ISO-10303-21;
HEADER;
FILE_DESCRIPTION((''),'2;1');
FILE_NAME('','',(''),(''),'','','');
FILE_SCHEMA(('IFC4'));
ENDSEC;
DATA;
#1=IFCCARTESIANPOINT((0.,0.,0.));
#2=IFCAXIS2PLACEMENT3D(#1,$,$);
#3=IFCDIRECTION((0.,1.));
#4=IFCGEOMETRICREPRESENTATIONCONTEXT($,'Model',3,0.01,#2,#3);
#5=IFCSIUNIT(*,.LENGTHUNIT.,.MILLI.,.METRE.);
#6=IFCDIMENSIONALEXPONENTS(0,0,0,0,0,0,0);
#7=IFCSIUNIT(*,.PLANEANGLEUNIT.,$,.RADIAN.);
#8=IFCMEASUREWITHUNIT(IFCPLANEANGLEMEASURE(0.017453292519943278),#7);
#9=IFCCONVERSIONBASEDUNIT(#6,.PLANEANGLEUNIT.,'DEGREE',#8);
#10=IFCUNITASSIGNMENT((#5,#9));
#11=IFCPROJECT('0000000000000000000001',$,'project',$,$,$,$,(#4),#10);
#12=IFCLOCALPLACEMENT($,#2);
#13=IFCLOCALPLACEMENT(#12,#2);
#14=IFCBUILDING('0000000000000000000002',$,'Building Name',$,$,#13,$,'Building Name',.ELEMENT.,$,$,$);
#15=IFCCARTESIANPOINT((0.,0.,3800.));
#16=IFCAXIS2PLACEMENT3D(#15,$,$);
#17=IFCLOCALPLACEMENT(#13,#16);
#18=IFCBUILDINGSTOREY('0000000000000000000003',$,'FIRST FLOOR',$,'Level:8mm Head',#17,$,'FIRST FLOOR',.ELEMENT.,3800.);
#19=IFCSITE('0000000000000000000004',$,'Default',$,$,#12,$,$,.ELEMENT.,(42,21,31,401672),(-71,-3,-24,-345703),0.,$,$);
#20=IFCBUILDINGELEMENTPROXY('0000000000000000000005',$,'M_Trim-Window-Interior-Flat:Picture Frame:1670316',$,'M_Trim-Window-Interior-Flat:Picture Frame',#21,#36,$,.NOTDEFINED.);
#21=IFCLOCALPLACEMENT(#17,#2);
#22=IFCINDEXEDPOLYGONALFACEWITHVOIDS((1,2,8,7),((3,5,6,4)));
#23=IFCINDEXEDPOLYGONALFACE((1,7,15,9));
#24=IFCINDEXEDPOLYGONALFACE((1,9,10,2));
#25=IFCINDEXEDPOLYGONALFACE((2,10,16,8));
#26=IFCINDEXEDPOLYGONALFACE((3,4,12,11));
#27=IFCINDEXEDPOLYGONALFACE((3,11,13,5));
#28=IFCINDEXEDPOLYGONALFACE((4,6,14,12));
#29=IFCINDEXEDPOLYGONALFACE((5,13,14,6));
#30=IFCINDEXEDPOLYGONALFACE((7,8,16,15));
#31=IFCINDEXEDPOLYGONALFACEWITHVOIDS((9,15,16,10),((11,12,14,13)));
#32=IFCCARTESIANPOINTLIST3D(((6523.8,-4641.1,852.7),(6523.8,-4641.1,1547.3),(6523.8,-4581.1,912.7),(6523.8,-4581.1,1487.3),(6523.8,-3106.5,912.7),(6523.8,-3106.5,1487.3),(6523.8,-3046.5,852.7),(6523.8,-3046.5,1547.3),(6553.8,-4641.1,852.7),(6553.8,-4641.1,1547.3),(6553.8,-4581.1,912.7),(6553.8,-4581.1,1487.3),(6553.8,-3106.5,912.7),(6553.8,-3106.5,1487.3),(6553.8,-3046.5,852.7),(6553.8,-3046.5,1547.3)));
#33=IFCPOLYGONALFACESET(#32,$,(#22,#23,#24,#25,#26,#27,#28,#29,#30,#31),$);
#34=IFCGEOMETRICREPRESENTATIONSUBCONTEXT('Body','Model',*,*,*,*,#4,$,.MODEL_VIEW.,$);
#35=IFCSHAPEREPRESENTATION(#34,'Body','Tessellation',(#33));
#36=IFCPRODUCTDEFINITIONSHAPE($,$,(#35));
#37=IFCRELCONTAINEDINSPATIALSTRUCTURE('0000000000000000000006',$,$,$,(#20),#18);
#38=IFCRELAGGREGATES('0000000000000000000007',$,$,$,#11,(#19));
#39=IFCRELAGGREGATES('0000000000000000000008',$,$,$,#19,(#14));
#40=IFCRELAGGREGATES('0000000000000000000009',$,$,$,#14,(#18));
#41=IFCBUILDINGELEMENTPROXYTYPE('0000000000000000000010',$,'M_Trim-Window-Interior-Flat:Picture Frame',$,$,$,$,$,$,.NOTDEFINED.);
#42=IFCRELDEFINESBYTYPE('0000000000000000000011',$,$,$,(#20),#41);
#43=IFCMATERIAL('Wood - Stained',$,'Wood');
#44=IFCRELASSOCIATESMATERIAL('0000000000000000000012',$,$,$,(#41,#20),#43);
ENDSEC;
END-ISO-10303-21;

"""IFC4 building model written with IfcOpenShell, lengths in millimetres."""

from ifc_helpers import new_model, entity, si_unit, converted_unit, direction, frame, origin, place, context, subcontext, project, spatial, indexed_curve, outline, extrude, source, transform, mapped, material, type_object, type_shapes, element, save


model = new_model("IFC4")

# Units and contexts
model_context = context("Model", 3, precision=0.01, world=origin(), true_north=direction((0.0, 1.0)))
body_context = subcontext(model_context, "Body", "Model", "MODEL_VIEW")
ifc_project = project(units=[si_unit("LENGTHUNIT", "METRE", prefix="MILLI"), converted_unit("PLANEANGLEUNIT", "DEGREE", entity("IfcPlaneAngleMeasure", 0.017453292519943278), si_unit("PLANEANGLEUNIT", "RADIAN"), dimensions=[0, 0, 0, 0, 0, 0, 0])], contexts=[model_context])

# Site, building, storey
site_placement = place(None, origin())
site = spatial("IfcSite", under=ifc_project, at=site_placement, Name="Default", CompositionType="ELEMENT", RefLatitude=(42, 21, 31, 401672), RefLongitude=(-71, -3, -24, -345703), RefElevation=0.0)
building_placement = place(site_placement, origin())
building = spatial("IfcBuilding", under=site, at=building_placement, Name="Building Name", LongName="Building Name", CompositionType="ELEMENT")
storey_placement = place(building_placement, frame((0.0, 0.0, 3800.0)))
storey = spatial("IfcBuildingStorey", under=building, at=storey_placement, Name="FIRST FLOOR", ObjectType="Level:8mm Head", LongName="FIRST FLOOR", CompositionType="ELEMENT", Elevation=3800.0)

# Shared definitions
ifc_material_1 = material(Name="Wood - Stained", Category="Wood")

# Building element proxy
building_element_proxy_type_1 = type_object("IfcBuildingElementProxyType", Name="M_Trim-Window-Interior-Flat:Picture Frame", PredefinedType="NOTDEFINED", material=ifc_material_1)
shared_shape_1 = source(origin(), body_context, "Body", "SweptSolid", [
    extrude(outline(indexed_curve([(-347.3, -797.3), (347.3, -797.3), (347.3, 797.3), (-347.3, 797.3), (-347.3, -797.3)], self_intersect=False), holes=[indexed_curve([(-287.3, -737.3), (-287.3, 737.3), (287.3, 737.3), (287.3, -737.3), (-287.3, -737.3)], self_intersect=False)]), frame((0.0, 300.0, 0.0), z_axis=(0.0, 0.0, 1.0), x_axis=(0.0, 1.0, 0.0)), (0.0, 0.0, 1.0), 30.0),
])
type_shapes(building_element_proxy_type_1, [shared_shape_1])
for number, where, z_axis, x_axis, name in (
    (1, (6523.8, -3843.8, 1500.0), (1.0, 0.0, 0.0), (0.0, -1.0, 0.0), "M_Trim-Window-Interior-Flat:Picture Frame:1670316"),
):
    element("IfcBuildingElementProxy", number, at=place(storey_placement, frame(where, z_axis=z_axis, x_axis=x_axis)), inside=storey, type_object=building_element_proxy_type_1, material=ifc_material_1, Name=name, ObjectType="M_Trim-Window-Interior-Flat:Picture Frame", PredefinedType="NOTDEFINED", context=body_context, shape_type="MappedRepresentation", body=[
        mapped(shared_shape_1, transform((0.0, 0.0, 0.0), scale=1.0)),
    ])

save(model, "model.ifc")
